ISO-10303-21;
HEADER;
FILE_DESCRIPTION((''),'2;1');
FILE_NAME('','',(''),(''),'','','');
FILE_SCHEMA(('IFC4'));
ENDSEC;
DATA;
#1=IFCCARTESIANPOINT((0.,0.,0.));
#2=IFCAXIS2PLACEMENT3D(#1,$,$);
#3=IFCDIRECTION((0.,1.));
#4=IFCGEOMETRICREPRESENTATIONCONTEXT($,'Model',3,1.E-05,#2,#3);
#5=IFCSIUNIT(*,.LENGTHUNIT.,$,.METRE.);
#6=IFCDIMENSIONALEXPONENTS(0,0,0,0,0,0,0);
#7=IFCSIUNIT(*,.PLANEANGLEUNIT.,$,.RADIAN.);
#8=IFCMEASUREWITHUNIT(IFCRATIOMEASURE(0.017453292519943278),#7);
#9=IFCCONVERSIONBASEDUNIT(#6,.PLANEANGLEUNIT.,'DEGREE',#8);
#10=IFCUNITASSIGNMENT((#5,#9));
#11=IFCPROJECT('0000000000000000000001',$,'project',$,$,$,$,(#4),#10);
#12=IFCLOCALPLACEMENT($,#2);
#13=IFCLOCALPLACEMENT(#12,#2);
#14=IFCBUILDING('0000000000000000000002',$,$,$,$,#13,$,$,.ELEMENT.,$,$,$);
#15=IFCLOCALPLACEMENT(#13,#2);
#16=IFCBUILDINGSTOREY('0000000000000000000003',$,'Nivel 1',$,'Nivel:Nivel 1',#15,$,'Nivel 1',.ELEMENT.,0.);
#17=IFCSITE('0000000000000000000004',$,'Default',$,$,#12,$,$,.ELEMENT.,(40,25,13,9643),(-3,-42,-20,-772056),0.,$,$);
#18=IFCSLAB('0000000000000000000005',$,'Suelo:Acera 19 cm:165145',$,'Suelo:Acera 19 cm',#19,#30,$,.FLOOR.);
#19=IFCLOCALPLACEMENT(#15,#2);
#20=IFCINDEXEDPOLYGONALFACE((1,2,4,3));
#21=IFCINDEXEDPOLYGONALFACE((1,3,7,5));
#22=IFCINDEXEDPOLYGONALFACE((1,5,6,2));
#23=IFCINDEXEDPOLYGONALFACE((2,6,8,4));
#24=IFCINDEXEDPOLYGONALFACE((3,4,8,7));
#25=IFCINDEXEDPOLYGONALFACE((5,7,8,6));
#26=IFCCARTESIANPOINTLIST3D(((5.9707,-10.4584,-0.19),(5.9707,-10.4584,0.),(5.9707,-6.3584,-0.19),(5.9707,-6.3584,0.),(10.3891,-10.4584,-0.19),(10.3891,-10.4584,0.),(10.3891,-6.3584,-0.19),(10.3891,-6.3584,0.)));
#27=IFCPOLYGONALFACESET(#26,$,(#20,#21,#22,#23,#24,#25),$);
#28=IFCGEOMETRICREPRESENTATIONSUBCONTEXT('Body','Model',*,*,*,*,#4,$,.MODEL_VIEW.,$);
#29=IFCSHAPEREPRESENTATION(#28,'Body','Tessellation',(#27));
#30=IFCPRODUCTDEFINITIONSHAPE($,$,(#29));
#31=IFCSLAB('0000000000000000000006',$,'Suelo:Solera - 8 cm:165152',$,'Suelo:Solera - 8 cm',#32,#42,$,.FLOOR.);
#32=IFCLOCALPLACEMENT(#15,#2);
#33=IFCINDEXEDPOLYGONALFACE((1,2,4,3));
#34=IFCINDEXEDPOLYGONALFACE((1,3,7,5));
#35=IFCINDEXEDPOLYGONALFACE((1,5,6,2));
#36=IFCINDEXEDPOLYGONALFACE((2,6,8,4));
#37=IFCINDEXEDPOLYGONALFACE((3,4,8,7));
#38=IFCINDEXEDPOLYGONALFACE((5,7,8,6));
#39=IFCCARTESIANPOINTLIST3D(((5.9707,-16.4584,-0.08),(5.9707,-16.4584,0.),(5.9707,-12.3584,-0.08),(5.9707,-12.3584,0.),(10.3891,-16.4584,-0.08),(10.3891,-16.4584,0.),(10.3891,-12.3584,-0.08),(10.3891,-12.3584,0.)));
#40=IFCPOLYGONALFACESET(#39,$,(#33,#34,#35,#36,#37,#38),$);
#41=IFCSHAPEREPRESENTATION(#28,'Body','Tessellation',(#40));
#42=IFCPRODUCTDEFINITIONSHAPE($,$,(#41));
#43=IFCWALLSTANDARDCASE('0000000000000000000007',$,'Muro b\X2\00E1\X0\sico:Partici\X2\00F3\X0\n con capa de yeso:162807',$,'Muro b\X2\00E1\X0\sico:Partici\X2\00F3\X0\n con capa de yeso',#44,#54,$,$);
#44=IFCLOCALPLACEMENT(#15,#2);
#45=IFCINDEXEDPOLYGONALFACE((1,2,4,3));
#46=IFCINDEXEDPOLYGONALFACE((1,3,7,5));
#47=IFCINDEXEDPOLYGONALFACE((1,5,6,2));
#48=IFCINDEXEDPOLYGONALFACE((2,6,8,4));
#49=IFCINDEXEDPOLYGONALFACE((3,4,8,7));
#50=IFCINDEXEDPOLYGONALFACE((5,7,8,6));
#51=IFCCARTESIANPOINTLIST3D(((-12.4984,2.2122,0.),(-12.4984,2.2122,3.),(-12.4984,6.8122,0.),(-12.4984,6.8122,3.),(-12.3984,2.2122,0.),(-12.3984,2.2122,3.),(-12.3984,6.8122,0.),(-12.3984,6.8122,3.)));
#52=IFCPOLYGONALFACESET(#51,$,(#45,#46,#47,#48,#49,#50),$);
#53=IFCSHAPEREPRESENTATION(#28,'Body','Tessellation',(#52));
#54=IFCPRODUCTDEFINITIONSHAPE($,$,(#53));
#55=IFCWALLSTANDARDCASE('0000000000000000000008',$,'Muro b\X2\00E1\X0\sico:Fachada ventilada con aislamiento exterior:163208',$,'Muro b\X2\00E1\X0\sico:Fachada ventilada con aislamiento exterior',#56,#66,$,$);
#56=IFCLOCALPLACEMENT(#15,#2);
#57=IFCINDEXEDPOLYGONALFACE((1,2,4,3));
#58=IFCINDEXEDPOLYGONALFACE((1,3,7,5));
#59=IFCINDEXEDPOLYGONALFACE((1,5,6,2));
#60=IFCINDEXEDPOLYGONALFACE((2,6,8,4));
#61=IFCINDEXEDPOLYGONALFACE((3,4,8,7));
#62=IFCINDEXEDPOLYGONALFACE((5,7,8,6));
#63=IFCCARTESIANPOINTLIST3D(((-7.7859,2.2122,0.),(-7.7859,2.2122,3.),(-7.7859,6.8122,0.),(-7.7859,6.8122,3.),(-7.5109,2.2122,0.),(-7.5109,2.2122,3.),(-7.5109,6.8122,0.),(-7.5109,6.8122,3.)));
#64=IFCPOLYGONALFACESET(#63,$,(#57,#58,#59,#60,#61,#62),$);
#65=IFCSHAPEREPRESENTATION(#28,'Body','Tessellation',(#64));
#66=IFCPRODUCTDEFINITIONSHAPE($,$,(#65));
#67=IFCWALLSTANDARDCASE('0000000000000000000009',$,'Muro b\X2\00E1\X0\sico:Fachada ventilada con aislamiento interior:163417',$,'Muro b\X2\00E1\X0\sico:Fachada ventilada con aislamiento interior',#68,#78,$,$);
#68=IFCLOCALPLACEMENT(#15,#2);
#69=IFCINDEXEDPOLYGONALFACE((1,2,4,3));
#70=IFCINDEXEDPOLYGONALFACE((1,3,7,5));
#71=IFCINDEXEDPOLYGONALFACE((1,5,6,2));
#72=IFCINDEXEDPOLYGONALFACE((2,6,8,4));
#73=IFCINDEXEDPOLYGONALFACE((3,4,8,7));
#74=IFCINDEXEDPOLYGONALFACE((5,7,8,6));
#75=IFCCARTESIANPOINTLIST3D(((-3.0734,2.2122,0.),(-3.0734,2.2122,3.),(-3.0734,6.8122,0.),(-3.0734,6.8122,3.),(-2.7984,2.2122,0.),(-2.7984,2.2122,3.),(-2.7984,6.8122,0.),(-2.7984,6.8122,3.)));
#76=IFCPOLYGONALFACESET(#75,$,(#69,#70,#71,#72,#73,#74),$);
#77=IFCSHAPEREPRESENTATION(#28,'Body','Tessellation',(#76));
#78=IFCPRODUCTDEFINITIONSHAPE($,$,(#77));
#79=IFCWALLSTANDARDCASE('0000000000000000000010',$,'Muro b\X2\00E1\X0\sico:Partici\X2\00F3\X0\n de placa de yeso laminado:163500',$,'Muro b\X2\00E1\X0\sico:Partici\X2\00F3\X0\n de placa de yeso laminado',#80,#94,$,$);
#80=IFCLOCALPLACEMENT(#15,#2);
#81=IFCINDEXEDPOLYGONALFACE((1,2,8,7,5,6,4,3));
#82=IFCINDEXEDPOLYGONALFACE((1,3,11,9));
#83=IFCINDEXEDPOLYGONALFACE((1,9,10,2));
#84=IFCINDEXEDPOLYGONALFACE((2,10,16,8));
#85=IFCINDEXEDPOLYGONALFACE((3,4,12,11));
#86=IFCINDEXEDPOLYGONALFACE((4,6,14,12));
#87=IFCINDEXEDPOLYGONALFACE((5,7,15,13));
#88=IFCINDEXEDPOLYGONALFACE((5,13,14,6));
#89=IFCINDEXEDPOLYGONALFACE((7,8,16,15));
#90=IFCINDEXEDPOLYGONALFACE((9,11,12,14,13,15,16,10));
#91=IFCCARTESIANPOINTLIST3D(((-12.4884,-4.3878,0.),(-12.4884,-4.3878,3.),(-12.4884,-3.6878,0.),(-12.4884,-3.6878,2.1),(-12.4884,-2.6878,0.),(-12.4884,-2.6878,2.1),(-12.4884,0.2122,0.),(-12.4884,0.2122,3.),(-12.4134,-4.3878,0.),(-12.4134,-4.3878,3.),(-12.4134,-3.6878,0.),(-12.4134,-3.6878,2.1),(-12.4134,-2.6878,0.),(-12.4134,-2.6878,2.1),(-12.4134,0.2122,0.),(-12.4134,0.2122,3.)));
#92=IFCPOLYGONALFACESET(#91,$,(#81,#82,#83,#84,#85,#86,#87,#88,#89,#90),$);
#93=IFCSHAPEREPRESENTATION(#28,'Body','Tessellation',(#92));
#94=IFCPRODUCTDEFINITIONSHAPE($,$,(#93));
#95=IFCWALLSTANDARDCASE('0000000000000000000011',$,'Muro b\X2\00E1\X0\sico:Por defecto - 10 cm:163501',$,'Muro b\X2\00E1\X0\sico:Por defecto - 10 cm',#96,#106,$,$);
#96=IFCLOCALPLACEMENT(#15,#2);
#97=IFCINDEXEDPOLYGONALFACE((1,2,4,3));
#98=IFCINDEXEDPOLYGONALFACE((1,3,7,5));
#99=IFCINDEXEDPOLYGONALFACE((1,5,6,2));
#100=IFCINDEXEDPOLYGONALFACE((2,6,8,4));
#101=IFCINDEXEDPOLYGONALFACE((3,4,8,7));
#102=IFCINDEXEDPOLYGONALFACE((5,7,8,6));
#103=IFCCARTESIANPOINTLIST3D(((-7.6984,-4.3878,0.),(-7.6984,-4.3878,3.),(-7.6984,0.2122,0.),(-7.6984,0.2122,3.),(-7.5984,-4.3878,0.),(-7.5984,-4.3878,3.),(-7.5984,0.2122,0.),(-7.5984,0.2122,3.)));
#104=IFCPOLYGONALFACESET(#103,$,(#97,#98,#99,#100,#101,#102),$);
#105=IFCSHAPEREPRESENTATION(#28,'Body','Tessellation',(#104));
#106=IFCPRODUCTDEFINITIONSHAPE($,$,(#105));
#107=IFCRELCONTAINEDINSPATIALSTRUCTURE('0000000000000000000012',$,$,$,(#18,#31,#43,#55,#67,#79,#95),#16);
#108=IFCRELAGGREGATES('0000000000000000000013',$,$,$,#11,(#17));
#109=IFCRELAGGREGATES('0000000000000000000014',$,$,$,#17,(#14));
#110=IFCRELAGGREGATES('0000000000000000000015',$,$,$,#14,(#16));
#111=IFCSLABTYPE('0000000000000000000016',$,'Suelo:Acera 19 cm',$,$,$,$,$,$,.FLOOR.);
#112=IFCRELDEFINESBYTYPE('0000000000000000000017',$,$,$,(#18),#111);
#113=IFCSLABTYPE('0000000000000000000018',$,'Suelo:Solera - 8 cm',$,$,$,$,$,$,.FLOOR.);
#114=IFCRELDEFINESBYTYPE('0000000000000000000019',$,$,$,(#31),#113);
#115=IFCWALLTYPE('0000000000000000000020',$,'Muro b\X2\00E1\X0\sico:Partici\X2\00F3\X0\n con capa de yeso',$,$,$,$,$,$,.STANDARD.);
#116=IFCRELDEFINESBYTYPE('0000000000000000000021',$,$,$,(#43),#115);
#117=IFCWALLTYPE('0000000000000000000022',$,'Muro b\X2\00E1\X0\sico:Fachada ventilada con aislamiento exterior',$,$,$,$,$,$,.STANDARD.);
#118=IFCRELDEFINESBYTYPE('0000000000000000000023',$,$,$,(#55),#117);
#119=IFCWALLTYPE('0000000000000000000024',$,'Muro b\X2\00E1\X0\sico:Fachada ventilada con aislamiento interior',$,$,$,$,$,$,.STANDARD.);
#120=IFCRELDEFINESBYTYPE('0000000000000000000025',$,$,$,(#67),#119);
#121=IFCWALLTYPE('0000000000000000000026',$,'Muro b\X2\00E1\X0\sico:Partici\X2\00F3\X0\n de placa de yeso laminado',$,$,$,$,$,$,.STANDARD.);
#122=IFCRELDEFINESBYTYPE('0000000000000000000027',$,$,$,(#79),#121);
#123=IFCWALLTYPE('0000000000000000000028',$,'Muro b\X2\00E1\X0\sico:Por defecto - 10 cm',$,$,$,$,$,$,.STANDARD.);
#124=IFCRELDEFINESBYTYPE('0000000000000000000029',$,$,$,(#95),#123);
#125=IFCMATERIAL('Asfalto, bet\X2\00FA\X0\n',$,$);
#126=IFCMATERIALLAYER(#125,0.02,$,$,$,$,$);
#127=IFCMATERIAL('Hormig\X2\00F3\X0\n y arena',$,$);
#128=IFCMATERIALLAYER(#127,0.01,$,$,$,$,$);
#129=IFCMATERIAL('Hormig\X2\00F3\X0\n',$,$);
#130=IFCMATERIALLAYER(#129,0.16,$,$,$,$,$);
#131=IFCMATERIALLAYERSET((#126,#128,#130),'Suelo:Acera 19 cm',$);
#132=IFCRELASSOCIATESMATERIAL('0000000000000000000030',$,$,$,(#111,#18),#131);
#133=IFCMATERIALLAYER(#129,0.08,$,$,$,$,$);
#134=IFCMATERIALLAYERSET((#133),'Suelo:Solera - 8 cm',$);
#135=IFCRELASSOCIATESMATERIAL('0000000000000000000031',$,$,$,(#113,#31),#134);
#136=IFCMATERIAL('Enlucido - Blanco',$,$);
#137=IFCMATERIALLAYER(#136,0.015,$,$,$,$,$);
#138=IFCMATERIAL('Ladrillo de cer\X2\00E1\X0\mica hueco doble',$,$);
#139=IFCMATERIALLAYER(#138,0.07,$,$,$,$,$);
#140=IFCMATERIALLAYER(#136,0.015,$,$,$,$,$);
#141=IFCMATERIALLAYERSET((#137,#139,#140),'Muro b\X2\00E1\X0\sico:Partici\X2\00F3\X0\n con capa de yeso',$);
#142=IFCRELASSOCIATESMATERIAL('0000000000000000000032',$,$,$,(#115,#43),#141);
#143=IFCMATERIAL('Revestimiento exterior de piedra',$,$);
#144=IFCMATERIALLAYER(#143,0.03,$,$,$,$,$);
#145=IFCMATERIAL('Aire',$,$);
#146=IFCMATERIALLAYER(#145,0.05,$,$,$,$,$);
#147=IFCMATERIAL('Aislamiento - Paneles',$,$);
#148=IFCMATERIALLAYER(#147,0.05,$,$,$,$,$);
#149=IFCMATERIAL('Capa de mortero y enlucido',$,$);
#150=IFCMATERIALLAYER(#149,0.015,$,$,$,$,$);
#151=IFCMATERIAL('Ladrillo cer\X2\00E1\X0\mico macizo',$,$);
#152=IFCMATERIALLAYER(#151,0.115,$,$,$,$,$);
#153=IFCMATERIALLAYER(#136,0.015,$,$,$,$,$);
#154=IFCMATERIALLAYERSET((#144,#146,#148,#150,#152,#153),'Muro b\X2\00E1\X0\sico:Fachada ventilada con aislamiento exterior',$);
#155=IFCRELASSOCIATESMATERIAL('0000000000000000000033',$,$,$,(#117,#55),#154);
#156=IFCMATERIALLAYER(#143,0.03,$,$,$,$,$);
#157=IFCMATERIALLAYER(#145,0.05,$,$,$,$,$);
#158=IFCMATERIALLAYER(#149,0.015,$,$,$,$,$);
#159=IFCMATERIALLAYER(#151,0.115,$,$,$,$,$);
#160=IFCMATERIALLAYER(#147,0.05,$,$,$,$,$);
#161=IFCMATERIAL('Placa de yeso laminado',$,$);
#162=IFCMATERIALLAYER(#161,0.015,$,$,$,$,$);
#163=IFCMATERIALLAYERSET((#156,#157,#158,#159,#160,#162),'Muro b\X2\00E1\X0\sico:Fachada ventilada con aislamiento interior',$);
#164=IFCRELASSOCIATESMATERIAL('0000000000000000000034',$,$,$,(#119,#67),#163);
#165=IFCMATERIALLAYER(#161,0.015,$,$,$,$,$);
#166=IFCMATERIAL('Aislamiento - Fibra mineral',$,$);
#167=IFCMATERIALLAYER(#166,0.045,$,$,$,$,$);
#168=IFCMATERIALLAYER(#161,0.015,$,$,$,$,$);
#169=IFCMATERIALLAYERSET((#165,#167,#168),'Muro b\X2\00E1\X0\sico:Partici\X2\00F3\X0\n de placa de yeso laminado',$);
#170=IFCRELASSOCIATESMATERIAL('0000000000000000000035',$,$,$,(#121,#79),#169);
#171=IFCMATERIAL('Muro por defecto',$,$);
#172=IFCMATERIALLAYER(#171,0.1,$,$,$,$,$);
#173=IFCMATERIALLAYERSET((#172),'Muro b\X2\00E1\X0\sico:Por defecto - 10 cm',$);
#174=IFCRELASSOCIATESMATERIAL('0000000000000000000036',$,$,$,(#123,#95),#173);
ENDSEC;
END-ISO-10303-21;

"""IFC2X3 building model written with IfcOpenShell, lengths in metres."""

from ifc_helpers import new_model, entity, si_unit, converted_unit, direction, frame, frame_2d, origin, place, context, subcontext, project, spatial, rectangle, extrude, material, layer, layer_set, layer_usage, type_object, element, save


model = new_model("IFC2X3")

# Units and contexts
model_context = context("Model", 3, precision=1e-05, world=origin(), true_north=direction((0.0, 1.0)))
body_context = subcontext(model_context, "Body", "Model", "MODEL_VIEW")
ifc_project = project(units=[si_unit("LENGTHUNIT", "METRE"), converted_unit("PLANEANGLEUNIT", "DEGREE", entity("IfcRatioMeasure", 0.017453292519943278), si_unit("PLANEANGLEUNIT", "RADIAN"), dimensions=[0, 0, 0, 0, 0, 0, 0])], contexts=[model_context])

# Site, building, storey
site_placement = place(None, origin())
site = spatial("IfcSite", under=ifc_project, at=site_placement, Name="Default", CompositionType="ELEMENT", RefLatitude=(40, 25, 13, 9643), RefLongitude=(-3, -42, -20, -772056), RefElevation=0.0)
building_placement = place(site_placement, origin())
building = spatial("IfcBuilding", under=site, at=building_placement, CompositionType="ELEMENT")
storey_placement = place(building_placement, origin())
storey = spatial("IfcBuildingStorey", under=building, at=storey_placement, Name="Nivel 1", ObjectType="Nivel:Nivel 1", LongName="Nivel 1", CompositionType="ELEMENT", Elevation=0.0)

# Slabs
ifc_material_1 = material(Name="Hormigón y arena")
ifc_material_2 = material(Name="Enlucido - Blanco")
ifc_material_3 = material(Name="Hormigón")
ifc_material_4 = material(Name="Aire")
ifc_material_5 = material(Name="Asfalto, betún")
ifc_layer_1 = layer(ifc_material_5, 0.02)
ifc_layer_2 = layer(ifc_material_1, 0.01)
ifc_layer_3 = layer(ifc_material_3, 0.16)
ifc_layer_set_1 = layer_set([ifc_layer_1, ifc_layer_2, ifc_layer_3], Name="Suelo:Acera 19 cm")
ifc_layer_usage_1 = layer_usage(ifc_layer_set_1, "AXIS3", "POSITIVE", 0.0)
slab_type_1 = type_object("IfcSlabType", Name="Suelo:Acera 19 cm", PredefinedType="FLOOR", material=ifc_layer_set_1)
slab_1_placement = place(storey_placement, origin())
element("IfcSlab", 1, at=slab_1_placement, inside=storey, type_object=slab_type_1, material=ifc_layer_usage_1, Name="Suelo:Acera 19 cm:165145", ObjectType="Suelo:Acera 19 cm", PredefinedType="FLOOR", context=body_context, shape_type="SweptSolid", body=[
    extrude(rectangle(XDim=4.1, YDim=4.4184, at=frame_2d((0.0, 0.0), x_axis=(1.0, 0.0))), frame((8.1799, -8.4084, 0.0), z_axis=(0.0, 0.0, -1.0), x_axis=(0.0, 1.0, 0.0)), (0.0, 0.0, 1.0), 0.19),
])
ifc_layer_4 = layer(ifc_material_3, 0.08)
ifc_layer_set_2 = layer_set([ifc_layer_4], Name="Suelo:Solera - 8 cm")
ifc_layer_usage_2 = layer_usage(ifc_layer_set_2, "AXIS3", "POSITIVE", 0.0)
slab_type_2 = type_object("IfcSlabType", Name="Suelo:Solera - 8 cm", PredefinedType="FLOOR", material=ifc_layer_set_2)
slab_2_placement = place(storey_placement, origin())
element("IfcSlab", 2, at=slab_2_placement, inside=storey, type_object=slab_type_2, material=ifc_layer_usage_2, Name="Suelo:Solera - 8 cm:165152", ObjectType="Suelo:Solera - 8 cm", PredefinedType="FLOOR", context=body_context, shape_type="SweptSolid", body=[
    extrude(rectangle(XDim=4.1, YDim=4.4184, at=frame_2d((0.0, 0.0), x_axis=(1.0, 0.0))), frame((8.1799, -14.4084, 0.0), z_axis=(0.0, 0.0, -1.0), x_axis=(0.0, 1.0, 0.0)), (0.0, 0.0, 1.0), 0.08),
])

# Walls
ifc_layer_5 = layer(ifc_material_2, 0.015)
ifc_material_6 = material(Name="Ladrillo de cerámica hueco doble")
ifc_layer_6 = layer(ifc_material_6, 0.07)
ifc_layer_7 = layer(ifc_material_2, 0.015)
ifc_layer_set_3 = layer_set([ifc_layer_5, ifc_layer_6, ifc_layer_7], Name="Muro básico:Partición con capa de yeso")
ifc_layer_usage_3 = layer_usage(ifc_layer_set_3, "AXIS2", "NEGATIVE", 0.05)
wall_type_1 = type_object("IfcWallType", Name="Muro básico:Partición con capa de yeso", PredefinedType="STANDARD", material=ifc_layer_set_3)
wall_1_placement = place(storey_placement, frame((-12.4484, 6.8122, 0.0), z_axis=(0.0, 0.0, 1.0), x_axis=(0.0, -1.0, 0.0)))
element("IfcWallStandardCase", 3, at=wall_1_placement, inside=storey, type_object=wall_type_1, material=ifc_layer_usage_3, Name="Muro básico:Partición con capa de yeso:162807", ObjectType="Muro básico:Partición con capa de yeso", context=body_context, shape_type="SweptSolid", body=[
    extrude(rectangle(XDim=4.6, YDim=0.1, at=frame_2d((2.3, 0.0), x_axis=(-1.0, 0.0))), origin(), (0.0, 0.0, 1.0), 3.0),
])
ifc_material_7 = material(Name="Revestimiento exterior de piedra")
ifc_layer_8 = layer(ifc_material_7, 0.03)
ifc_layer_9 = layer(ifc_material_4, 0.05)
ifc_material_8 = material(Name="Aislamiento - Paneles")
ifc_layer_10 = layer(ifc_material_8, 0.05)
ifc_material_9 = material(Name="Capa de mortero y enlucido")
ifc_layer_11 = layer(ifc_material_9, 0.015)
ifc_material_10 = material(Name="Ladrillo cerámico macizo")
ifc_layer_12 = layer(ifc_material_10, 0.115)
ifc_layer_13 = layer(ifc_material_2, 0.015)
ifc_layer_set_4 = layer_set([ifc_layer_8, ifc_layer_9, ifc_layer_10, ifc_layer_11, ifc_layer_12, ifc_layer_13], Name="Muro básico:Fachada ventilada con aislamiento exterior")
ifc_layer_usage_4 = layer_usage(ifc_layer_set_4, "AXIS2", "NEGATIVE", 0.1375)
wall_type_2 = type_object("IfcWallType", Name="Muro básico:Fachada ventilada con aislamiento exterior", PredefinedType="STANDARD", material=ifc_layer_set_4)
wall_2_placement = place(storey_placement, frame((-7.6484, 6.8122, 0.0), z_axis=(0.0, 0.0, 1.0), x_axis=(0.0, -1.0, 0.0)))
element("IfcWallStandardCase", 4, at=wall_2_placement, inside=storey, type_object=wall_type_2, material=ifc_layer_usage_4, Name="Muro básico:Fachada ventilada con aislamiento exterior:163208", ObjectType="Muro básico:Fachada ventilada con aislamiento exterior", context=body_context, shape_type="SweptSolid", body=[
    extrude(rectangle(XDim=4.6, YDim=0.275, at=frame_2d((2.3, 0.0), x_axis=(-1.0, 0.0))), origin(), (0.0, 0.0, 1.0), 3.0),
])
ifc_layer_14 = layer(ifc_material_7, 0.03)
ifc_layer_15 = layer(ifc_material_4, 0.05)
ifc_layer_16 = layer(ifc_material_9, 0.015)
ifc_layer_17 = layer(ifc_material_10, 0.115)
ifc_layer_18 = layer(ifc_material_8, 0.05)
ifc_material_11 = material(Name="Placa de yeso laminado")
ifc_layer_19 = layer(ifc_material_11, 0.015)
ifc_layer_set_5 = layer_set([ifc_layer_14, ifc_layer_15, ifc_layer_16, ifc_layer_17, ifc_layer_18, ifc_layer_19], Name="Muro básico:Fachada ventilada con aislamiento interior")
ifc_layer_usage_5 = layer_usage(ifc_layer_set_5, "AXIS2", "NEGATIVE", 0.1375)
wall_type_3 = type_object("IfcWallType", Name="Muro básico:Fachada ventilada con aislamiento interior", PredefinedType="STANDARD", material=ifc_layer_set_5)
wall_3_placement = place(storey_placement, frame((-2.9359, 6.8122, 0.0), z_axis=(0.0, 0.0, 1.0), x_axis=(0.0, -1.0, 0.0)))
element("IfcWallStandardCase", 5, at=wall_3_placement, inside=storey, type_object=wall_type_3, material=ifc_layer_usage_5, Name="Muro básico:Fachada ventilada con aislamiento interior:163417", ObjectType="Muro básico:Fachada ventilada con aislamiento interior", context=body_context, shape_type="SweptSolid", body=[
    extrude(rectangle(XDim=4.6, YDim=0.275, at=frame_2d((2.3, 0.0), x_axis=(-1.0, 0.0))), origin(), (0.0, 0.0, 1.0), 3.0),
])

# Wall, opening
ifc_layer_20 = layer(ifc_material_11, 0.015)
ifc_material_12 = material(Name="Aislamiento - Fibra mineral")
ifc_layer_21 = layer(ifc_material_12, 0.045)
ifc_layer_22 = layer(ifc_material_11, 0.015)
ifc_layer_set_6 = layer_set([ifc_layer_20, ifc_layer_21, ifc_layer_22], Name="Muro básico:Partición de placa de yeso laminado")
ifc_layer_usage_6 = layer_usage(ifc_layer_set_6, "AXIS2", "NEGATIVE", 0.0375)
wall_type_4 = type_object("IfcWallType", Name="Muro básico:Partición de placa de yeso laminado", PredefinedType="STANDARD", material=ifc_layer_set_6)
wall_4_placement = place(storey_placement, frame((-12.4509, 0.2122, 0.0), z_axis=(0.0, 0.0, 1.0), x_axis=(0.0, -1.0, 0.0)))
wall_4 = element("IfcWallStandardCase", 6, at=wall_4_placement, inside=storey, type_object=wall_type_4, material=ifc_layer_usage_6, Name="Muro básico:Partición de placa de yeso laminado:163500", ObjectType="Muro básico:Partición de placa de yeso laminado", context=body_context, shape_type="SweptSolid", body=[
    extrude(rectangle(XDim=4.6, YDim=0.075, at=frame_2d((2.3, 0.0), x_axis=(1.0, 0.0))), origin(), (0.0, 0.0, 1.0), 3.0),
])
opening_1_placement = place(wall_4_placement, frame((2.9, -0.0375, 0.0)))
element("IfcOpeningElement", 7, at=opening_1_placement, cuts=wall_4, ObjectType="Opening", context=body_context, shape_type="SweptSolid", body=[
    extrude(rectangle(XDim=2.1, YDim=1.0, at=frame_2d((1.05, 0.5), x_axis=(1.0, 0.0))), frame((0.0, 0.0, 0.0), z_axis=(0.0, 1.0, 0.0), x_axis=(0.0, 0.0, 1.0)), (0.0, 0.0, 1.0), 0.075),
])

# Wall
ifc_material_13 = material(Name="Muro por defecto")
ifc_layer_23 = layer(ifc_material_13, 0.1)
ifc_layer_set_7 = layer_set([ifc_layer_23], Name="Muro básico:Por defecto - 10 cm")
ifc_layer_usage_7 = layer_usage(ifc_layer_set_7, "AXIS2", "NEGATIVE", 0.05)
wall_type_5 = type_object("IfcWallType", Name="Muro básico:Por defecto - 10 cm", PredefinedType="STANDARD", material=ifc_layer_set_7)
wall_5_placement = place(storey_placement, frame((-7.6484, 0.2122, 0.0), z_axis=(0.0, 0.0, 1.0), x_axis=(0.0, -1.0, 0.0)))
element("IfcWallStandardCase", 8, at=wall_5_placement, inside=storey, type_object=wall_type_5, material=ifc_layer_usage_7, Name="Muro básico:Por defecto - 10 cm:163501", ObjectType="Muro básico:Por defecto - 10 cm", context=body_context, shape_type="SweptSolid", body=[
    extrude(rectangle(XDim=4.6, YDim=0.1, at=frame_2d((2.3, 0.0), x_axis=(-1.0, 0.0))), origin(), (0.0, 0.0, 1.0), 3.0),
])

save(model, "model.ifc")
